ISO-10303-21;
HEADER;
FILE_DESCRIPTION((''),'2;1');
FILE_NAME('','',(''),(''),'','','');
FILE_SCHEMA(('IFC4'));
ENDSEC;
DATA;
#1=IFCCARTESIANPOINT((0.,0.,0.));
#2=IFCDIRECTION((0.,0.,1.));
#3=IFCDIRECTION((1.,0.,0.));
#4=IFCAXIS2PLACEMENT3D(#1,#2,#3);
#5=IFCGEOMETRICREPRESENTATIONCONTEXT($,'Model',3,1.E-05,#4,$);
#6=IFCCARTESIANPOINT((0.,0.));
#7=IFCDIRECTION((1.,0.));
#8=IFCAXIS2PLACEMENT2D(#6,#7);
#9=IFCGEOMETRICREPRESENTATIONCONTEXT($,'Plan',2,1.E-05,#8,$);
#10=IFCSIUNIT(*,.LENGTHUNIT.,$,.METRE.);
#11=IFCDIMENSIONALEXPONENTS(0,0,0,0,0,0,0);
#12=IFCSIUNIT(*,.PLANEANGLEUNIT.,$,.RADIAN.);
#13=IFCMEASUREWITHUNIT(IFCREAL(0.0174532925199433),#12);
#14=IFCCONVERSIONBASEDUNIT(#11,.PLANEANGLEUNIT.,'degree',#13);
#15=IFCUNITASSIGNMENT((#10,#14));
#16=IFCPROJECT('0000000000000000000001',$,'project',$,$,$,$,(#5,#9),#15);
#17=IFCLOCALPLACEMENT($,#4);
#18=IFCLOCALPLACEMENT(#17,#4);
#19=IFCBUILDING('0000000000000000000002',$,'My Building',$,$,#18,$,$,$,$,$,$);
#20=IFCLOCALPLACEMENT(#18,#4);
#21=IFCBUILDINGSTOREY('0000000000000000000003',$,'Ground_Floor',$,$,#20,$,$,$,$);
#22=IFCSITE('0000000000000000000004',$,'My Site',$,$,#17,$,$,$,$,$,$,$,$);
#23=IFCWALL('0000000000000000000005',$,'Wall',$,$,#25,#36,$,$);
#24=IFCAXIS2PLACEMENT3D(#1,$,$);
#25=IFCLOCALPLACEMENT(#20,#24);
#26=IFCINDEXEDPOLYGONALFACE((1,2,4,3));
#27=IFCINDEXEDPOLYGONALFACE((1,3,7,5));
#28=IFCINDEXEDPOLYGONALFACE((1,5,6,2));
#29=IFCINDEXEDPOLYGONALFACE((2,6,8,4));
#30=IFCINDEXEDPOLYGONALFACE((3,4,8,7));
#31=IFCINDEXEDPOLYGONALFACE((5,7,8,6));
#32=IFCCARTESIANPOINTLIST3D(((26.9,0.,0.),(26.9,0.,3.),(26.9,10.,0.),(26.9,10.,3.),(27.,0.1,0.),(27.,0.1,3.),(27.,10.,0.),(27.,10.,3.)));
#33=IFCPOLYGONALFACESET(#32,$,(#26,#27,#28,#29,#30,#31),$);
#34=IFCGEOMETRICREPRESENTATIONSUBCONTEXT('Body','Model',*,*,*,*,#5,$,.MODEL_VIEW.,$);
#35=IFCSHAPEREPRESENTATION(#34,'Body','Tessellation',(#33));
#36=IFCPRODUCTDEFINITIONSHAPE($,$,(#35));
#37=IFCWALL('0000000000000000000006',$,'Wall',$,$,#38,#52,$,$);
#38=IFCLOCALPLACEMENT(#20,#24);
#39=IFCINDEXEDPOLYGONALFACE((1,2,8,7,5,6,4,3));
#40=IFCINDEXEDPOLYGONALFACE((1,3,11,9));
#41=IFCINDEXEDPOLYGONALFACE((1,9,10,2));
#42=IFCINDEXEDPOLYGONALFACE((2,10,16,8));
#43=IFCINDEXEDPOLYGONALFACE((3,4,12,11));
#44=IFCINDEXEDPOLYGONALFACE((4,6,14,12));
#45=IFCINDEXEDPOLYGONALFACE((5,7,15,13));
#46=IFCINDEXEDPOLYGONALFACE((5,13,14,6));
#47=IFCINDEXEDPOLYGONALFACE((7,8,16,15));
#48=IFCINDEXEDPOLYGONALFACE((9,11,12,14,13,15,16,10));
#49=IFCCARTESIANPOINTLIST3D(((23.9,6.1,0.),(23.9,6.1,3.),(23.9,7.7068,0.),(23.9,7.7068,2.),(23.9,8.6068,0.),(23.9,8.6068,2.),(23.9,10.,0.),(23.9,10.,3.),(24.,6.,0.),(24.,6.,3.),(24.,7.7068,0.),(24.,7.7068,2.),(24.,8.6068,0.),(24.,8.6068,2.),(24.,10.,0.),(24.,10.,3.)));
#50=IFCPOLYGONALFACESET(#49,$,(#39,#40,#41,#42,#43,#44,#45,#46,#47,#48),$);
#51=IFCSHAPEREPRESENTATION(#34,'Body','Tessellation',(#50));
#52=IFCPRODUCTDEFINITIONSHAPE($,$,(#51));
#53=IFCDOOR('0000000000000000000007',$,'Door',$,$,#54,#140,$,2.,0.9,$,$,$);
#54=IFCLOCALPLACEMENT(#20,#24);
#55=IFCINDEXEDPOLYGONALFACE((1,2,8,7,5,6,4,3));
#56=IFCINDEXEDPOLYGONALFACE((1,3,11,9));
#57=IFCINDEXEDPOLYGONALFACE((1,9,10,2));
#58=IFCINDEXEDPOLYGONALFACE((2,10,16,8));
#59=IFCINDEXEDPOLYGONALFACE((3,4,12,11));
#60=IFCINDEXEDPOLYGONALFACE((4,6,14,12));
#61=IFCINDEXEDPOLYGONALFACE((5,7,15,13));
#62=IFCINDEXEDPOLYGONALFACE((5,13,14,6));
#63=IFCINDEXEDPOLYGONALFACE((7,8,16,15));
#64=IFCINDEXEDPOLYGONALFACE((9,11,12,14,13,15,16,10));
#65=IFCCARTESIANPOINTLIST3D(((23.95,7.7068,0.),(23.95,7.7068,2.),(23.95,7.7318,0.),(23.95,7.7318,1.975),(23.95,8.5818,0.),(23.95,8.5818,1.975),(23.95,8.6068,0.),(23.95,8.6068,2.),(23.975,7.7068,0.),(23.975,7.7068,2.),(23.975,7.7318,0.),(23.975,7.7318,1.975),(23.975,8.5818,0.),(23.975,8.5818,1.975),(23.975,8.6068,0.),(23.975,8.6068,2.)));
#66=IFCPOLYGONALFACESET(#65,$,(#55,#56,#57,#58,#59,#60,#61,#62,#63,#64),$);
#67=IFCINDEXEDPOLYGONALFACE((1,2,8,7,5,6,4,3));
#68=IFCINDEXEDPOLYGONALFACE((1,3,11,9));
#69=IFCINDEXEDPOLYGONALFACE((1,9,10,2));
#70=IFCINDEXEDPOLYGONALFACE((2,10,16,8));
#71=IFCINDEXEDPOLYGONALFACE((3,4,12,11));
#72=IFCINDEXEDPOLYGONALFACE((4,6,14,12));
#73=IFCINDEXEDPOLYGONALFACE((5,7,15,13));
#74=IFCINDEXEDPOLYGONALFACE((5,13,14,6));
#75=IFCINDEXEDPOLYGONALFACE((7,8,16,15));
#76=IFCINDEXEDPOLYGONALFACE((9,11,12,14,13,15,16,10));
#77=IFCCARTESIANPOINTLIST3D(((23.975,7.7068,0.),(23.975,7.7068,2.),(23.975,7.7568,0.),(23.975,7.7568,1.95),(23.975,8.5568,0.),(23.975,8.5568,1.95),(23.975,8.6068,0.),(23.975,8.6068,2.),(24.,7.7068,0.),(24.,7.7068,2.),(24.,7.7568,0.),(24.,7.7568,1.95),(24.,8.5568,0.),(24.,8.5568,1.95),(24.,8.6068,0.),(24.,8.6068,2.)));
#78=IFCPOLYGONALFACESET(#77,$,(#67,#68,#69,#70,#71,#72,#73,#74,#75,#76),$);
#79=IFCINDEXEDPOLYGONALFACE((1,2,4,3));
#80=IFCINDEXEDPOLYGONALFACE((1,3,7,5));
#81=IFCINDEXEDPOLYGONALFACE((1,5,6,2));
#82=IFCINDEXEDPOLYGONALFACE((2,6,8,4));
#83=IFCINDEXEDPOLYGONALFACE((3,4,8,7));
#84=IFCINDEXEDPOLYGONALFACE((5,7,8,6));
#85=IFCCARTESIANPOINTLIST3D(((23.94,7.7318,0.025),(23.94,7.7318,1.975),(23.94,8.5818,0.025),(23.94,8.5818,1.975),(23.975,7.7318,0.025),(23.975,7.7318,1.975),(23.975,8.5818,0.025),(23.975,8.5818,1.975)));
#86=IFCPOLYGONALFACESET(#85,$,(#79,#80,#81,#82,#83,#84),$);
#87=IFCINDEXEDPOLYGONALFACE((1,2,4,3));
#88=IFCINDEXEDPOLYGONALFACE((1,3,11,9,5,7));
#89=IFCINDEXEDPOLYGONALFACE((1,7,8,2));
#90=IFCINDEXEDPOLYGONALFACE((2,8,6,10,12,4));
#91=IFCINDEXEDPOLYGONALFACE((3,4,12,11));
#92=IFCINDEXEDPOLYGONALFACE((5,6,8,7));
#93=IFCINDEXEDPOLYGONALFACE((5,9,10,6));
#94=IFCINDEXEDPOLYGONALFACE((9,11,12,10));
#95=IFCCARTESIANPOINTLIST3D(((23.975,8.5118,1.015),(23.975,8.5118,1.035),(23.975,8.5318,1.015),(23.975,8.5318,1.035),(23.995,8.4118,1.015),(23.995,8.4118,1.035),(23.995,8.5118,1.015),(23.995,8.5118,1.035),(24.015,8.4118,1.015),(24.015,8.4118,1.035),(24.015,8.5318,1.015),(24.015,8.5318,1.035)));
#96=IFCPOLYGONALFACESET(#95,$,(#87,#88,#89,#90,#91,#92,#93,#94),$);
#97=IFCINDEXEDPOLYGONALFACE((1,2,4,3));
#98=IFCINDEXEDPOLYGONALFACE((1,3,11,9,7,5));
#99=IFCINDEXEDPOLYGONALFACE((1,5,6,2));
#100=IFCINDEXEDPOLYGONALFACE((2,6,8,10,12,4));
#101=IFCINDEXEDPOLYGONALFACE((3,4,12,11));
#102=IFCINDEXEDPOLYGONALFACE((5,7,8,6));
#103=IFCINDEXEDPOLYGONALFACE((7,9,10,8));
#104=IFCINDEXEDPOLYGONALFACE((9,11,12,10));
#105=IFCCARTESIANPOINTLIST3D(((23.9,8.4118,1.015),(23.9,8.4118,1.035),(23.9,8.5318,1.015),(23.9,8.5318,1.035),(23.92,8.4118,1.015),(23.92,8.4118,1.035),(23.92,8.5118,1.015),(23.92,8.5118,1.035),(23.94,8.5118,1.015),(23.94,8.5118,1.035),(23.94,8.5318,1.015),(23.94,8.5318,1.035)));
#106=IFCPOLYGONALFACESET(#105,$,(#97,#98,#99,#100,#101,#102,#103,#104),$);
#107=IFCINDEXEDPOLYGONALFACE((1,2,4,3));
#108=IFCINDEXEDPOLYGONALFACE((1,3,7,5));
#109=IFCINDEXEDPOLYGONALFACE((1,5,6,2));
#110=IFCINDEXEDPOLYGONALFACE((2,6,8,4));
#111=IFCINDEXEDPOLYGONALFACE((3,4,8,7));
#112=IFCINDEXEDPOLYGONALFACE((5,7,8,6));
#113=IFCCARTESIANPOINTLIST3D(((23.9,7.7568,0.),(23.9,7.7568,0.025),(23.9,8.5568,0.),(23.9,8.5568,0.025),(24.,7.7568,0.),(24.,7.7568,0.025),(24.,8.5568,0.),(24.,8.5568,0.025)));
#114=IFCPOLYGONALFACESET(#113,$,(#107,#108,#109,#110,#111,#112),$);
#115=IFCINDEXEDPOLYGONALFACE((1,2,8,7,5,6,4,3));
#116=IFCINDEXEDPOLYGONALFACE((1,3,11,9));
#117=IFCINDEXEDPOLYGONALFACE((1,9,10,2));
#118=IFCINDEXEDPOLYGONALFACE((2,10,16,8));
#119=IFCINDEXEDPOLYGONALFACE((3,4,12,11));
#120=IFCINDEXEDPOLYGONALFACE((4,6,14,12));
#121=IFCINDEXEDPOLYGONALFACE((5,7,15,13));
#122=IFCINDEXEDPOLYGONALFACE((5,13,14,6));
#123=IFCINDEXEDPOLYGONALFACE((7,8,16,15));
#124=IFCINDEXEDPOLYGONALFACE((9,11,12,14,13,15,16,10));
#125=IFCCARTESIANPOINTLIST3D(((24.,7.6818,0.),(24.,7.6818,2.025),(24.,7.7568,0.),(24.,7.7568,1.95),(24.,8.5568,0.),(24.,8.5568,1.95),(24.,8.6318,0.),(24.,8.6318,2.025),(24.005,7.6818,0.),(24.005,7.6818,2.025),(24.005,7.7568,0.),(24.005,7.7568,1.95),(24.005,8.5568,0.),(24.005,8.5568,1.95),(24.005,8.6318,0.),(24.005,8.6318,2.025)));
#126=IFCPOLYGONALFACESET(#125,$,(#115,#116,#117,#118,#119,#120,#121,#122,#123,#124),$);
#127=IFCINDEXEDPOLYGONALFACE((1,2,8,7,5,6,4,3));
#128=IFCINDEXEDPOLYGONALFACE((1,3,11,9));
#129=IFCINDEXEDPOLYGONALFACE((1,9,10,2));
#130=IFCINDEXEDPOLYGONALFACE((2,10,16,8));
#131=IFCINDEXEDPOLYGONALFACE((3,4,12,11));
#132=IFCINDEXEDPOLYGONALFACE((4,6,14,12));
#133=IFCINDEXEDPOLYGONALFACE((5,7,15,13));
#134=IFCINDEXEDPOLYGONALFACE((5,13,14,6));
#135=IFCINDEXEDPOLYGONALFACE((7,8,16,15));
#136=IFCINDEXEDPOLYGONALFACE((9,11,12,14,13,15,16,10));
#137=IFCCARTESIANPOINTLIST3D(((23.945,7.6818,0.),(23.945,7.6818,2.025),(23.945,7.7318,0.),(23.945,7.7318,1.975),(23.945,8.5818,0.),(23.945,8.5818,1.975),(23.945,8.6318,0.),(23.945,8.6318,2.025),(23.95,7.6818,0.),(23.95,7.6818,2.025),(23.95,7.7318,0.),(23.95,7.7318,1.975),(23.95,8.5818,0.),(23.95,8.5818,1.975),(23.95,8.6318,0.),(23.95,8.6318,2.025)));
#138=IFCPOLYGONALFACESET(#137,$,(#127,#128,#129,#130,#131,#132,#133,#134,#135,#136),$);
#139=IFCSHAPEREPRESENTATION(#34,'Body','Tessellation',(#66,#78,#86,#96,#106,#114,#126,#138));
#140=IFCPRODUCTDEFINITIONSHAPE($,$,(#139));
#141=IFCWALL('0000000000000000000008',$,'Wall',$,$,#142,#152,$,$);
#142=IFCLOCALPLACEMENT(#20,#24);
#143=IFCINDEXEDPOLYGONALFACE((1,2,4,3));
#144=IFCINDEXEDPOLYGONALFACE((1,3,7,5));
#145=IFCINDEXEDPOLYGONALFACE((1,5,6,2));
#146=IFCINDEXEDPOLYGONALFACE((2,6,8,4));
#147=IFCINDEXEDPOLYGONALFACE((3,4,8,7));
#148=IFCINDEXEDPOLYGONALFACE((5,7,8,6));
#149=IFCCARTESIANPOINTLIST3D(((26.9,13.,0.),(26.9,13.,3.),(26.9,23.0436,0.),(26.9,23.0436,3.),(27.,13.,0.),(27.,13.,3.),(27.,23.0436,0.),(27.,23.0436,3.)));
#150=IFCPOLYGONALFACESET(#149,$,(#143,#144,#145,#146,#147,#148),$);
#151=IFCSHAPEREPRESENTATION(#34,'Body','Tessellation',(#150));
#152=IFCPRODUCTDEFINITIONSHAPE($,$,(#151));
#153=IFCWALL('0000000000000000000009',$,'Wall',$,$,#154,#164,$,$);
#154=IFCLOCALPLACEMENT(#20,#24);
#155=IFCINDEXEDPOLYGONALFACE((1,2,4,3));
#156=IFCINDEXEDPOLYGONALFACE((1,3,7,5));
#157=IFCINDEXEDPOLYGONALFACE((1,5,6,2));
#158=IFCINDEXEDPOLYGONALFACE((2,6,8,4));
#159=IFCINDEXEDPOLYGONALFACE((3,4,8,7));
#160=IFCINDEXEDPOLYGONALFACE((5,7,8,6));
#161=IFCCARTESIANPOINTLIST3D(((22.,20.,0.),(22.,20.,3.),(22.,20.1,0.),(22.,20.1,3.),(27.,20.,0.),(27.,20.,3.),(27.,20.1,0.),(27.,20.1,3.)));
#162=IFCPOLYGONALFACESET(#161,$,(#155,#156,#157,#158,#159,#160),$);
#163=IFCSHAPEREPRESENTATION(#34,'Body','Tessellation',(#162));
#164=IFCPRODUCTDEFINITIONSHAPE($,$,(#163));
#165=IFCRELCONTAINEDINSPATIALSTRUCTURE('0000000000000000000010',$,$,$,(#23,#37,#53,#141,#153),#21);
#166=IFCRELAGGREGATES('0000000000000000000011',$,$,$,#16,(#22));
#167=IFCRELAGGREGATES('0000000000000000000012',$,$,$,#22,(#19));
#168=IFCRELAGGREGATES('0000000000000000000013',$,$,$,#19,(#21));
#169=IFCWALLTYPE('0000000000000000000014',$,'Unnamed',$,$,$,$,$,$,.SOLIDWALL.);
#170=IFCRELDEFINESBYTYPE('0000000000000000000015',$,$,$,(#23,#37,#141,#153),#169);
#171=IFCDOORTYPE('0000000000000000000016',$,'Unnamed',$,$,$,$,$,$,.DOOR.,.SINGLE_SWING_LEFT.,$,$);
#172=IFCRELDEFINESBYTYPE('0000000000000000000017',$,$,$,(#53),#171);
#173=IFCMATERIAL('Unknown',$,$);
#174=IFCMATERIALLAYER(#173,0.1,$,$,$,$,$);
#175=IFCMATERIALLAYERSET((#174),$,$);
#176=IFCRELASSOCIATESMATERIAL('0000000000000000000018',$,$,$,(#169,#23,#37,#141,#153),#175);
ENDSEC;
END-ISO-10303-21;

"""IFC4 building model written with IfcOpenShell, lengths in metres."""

from ifc_helpers import new_model, entity, si_unit, converted_unit, frame, origin_with_axes, origin_2d_with_axis, place, context, subcontext, project, spatial, line, indexed_curve, outline, extrude, shape, source, transform, mapped, material, layer, layer_set, layer_usage, type_object, type_shapes, element, fill, save


model = new_model("IFC4")

# Units and contexts
model_context = context("Model", 3, precision=1e-05, world=origin_with_axes())
plan_context = context("Plan", 2, precision=1e-05, world=origin_2d_with_axis())
body_context_1 = subcontext(model_context, "Body", "Model", "MODEL_VIEW")
body_context_2 = subcontext(plan_context, "Body", "Plan", "PLAN_VIEW")
ifc_project = project(units=[si_unit("LENGTHUNIT", "METRE"), converted_unit("PLANEANGLEUNIT", "degree", entity("IfcReal", 0.0174532925199433), si_unit("PLANEANGLEUNIT", "RADIAN"), dimensions=[0, 0, 0, 0, 0, 0, 0])], contexts=[model_context, plan_context])

# Site, building, storey
site_placement = place(None, origin_with_axes())
site = spatial("IfcSite", under=ifc_project, at=site_placement, Name="My Site")
building_placement = place(site_placement, origin_with_axes())
building = spatial("IfcBuilding", under=site, at=building_placement, Name="My Building")
storey_placement = place(building_placement, origin_with_axes())
storey = spatial("IfcBuildingStorey", under=building, at=storey_placement, Name="Ground_Floor")

# Wall
ifc_material = material(Name="Unknown")
ifc_layer = layer(ifc_material, 0.1)
ifc_layer_set = layer_set([ifc_layer])
ifc_layer_usage_1 = layer_usage(ifc_layer_set, "AXIS2", "POSITIVE", 0.0)
wall_type = type_object("IfcWallType", Name="Unnamed", PredefinedType="SOLIDWALL", material=ifc_layer_set)
wall_1_placement = place(storey_placement, frame((27.0, 0.0, 0.0), z_axis=(0.0, 0.0, 1.0), x_axis=(0.0, 1.0, 0.0)))
element("IfcWall", 1, at=wall_1_placement, inside=storey, type_object=wall_type, material=ifc_layer_usage_1, Name="Wall", context=body_context_1, shape_type="SweptSolid", body=[
    extrude(outline(indexed_curve([(0.1, 0.0), (0.0, 0.1), (10.0, 0.1), (10.0, 0.0)], segments=[line(1, 2, 3, 4, 1)])), origin_with_axes(), (0.0, 0.0, 1.0), 3.0),
])

# Wall, opening, door
ifc_layer_usage_2 = layer_usage(ifc_layer_set, "AXIS2", "POSITIVE", 0.0)
wall_2_placement = place(storey_placement, frame((24.0, 6.0, 0.0), z_axis=(0.0, 0.0, 1.0), x_axis=(0.0, 1.0, 0.0)))
wall_2 = element("IfcWall", 2, at=wall_2_placement, inside=storey, type_object=wall_type, material=ifc_layer_usage_2, Name="Wall", context=body_context_1, shape_type="SweptSolid", body=[
    extrude(outline(indexed_curve([(0.0, 0.0), (0.1, 0.1), (4.0, 0.1), (4.0, 0.0)], segments=[line(1, 2, 3, 4, 1)])), origin_with_axes(), (0.0, 0.0, 1.0), 3.0),
])
shared_shape_1 = source(origin_with_axes(), body_context_1, "Body", "SweptSolid", [
    extrude(outline(indexed_curve([(0.0, 0.0), (0.9, 0.0), (0.9, 2.0), (0.0, 2.0)], segments=[line(1, 2, 3, 4, 1)])), frame((0.0, -0.6, 0.0), z_axis=(0.0, -1.0, 0.0), x_axis=(1.0, 0.0, 0.0)), (0.0, 0.0, -1.0), 1.2),
])
opening_1_placement = place(wall_2_placement, frame((1.7068, 0.0, 0.0), z_axis=(0.0, 0.0, 1.0), x_axis=(1.0, 0.0, 0.0)))
opening_1 = element("IfcOpeningElement", 3, at=opening_1_placement, cuts=wall_2, PredefinedType="OPENING", context=body_context_1, shape_type="MappedRepresentation", body=[
    mapped(shared_shape_1, transform((0.0, 0.0, 0.0), x_axis=(1.0, 0.0, 0.0), y_axis=(0.0, 1.0, 0.0), z_axis=(0.0, 0.0, 1.0), scale=1.0)),
])
door_type_1 = type_object("IfcDoorType", Name="Unnamed", OperationType="SINGLE_SWING_LEFT", PredefinedType="DOOR")
shared_shape_2 = source(origin_with_axes(), body_context_1, "Body", "SweptSolid", [
    extrude(outline(indexed_curve([(0.0, 0.0), (0.0, 2.0), (0.9, 2.0), (0.9, 0.0), (0.875, 0.0), (0.875, 1.975), (0.025, 1.975), (0.025, 0.0)], segments=[line(1, 2, 3, 4, 5, 6, 7, 8, 1)])), frame((0.0, 0.025, 0.0), z_axis=(0.0, -1.0, 0.0), x_axis=(1.0, 0.0, 0.0)), (0.0, 0.0, -1.0), 0.025),
    extrude(outline(indexed_curve([(0.0, 0.0), (0.0, 2.0), (0.9, 2.0), (0.9, 0.0), (0.85, 0.0), (0.85, 1.95), (0.05, 1.95), (0.05, 0.0)], segments=[line(1, 2, 3, 4, 5, 6, 7, 8, 1)])), frame((0.0, 0.0, 0.0), z_axis=(0.0, -1.0, 0.0), x_axis=(1.0, 0.0, 0.0)), (0.0, 0.0, -1.0), 0.025),
    extrude(outline(indexed_curve([(0.0, 0.0), (0.85, 0.0), (0.85, 0.035), (0.0, 0.035)], segments=[line(1, 2, 3, 4, 1)])), frame((0.025, 0.025, 0.025), z_axis=(0.0, 0.0, 1.0), x_axis=(1.0, 0.0, 0.0)), (0.0, 0.0, 1.0), 1.95),
    extrude(outline(indexed_curve([(0.0, 0.0), (0.0, -0.04), (-0.12, -0.04), (-0.12, -0.02), (-0.02, -0.02), (-0.02, 0.0)], segments=[line(1, 2, 3, 4, 5, 6, 1)])), frame((0.825, 0.025, 1.015), z_axis=(0.0, 0.0, 1.0), x_axis=(1.0, 0.0, 0.0)), (0.0, 0.0, 1.0), 0.02),
    extrude(outline(indexed_curve([(0.0, 0.0), (0.0, 0.04), (-0.12, 0.04), (-0.12, 0.02), (-0.02, 0.02), (-0.02, 0.0)], segments=[line(1, 2, 3, 4, 5, 6, 1)])), frame((0.825, 0.06, 1.015), z_axis=(0.0, 0.0, 1.0), x_axis=(1.0, 0.0, 0.0)), (0.0, 0.0, 1.0), 0.02),
    extrude(outline(indexed_curve([(0.0, 0.0), (0.8, 0.0), (0.8, 0.1), (0.0, 0.1)], segments=[line(1, 2, 3, 4, 1)])), frame((0.05, 0.0, 0.0), z_axis=(0.0, 0.0, 1.0), x_axis=(1.0, 0.0, 0.0)), (0.0, 0.0, 1.0), 0.025),
    extrude(outline(indexed_curve([(0.0, 0.0), (0.0, 2.025), (0.95, 2.025), (0.95, 0.0), (0.875, 0.0), (0.875, 1.95), (0.075, 1.95), (0.075, 0.0)], segments=[line(1, 2, 3, 4, 5, 6, 7, 8, 1)])), frame((-0.025, -0.005, 0.0), z_axis=(0.0, -1.0, 0.0), x_axis=(1.0, 0.0, 0.0)), (0.0, 0.0, -1.0), 0.005),
    extrude(outline(indexed_curve([(0.0, 0.0), (0.0, 2.025), (0.95, 2.025), (0.95, 0.0), (0.9, 0.0), (0.9, 1.975), (0.05, 1.975), (0.05, 0.0)], segments=[line(1, 2, 3, 4, 5, 6, 7, 8, 1)])), frame((-0.025, 0.05, 0.0), z_axis=(0.0, -1.0, 0.0), x_axis=(1.0, 0.0, 0.0)), (0.0, 0.0, -1.0), 0.005),
])
shared_shape_3 = source(origin_with_axes(), body_context_2, "Body", "Curve2D", [
    entity("IfcIndexedPolyCurve", entity("IfcCartesianPointList2D", [[0.0, 0.0], [0.0, 0.05], [0.025, 0.05], [0.025, 0.025], [0.05, 0.025], [0.05, 0.0]]), [entity("IfcLineIndex", [1, 2, 3, 4, 5, 6, 1])]),
    entity("IfcIndexedPolyCurve", entity("IfcCartesianPointList2D", [[0.9, 0.0], [0.9, 0.05], [0.875, 0.05], [0.875, 0.025], [0.85, 0.025], [0.85, 0.0]]), [entity("IfcLineIndex", [1, 2, 3, 4, 5, 6, 1])]),
    entity("IfcTrimmedCurve", entity("IfcEllipse", entity("IfcAxis2Placement2D", entity("IfcCartesianPoint", [0.06, 0.05]), entity("IfcDirection", [1.0, 0.0])), 0.815, 0.85), [entity("IfcCartesianPoint", [0.875, 0.05])], [entity("IfcCartesianPoint", [0.06, 0.9])], True, "CARTESIAN"),
    entity("IfcIndexedPolyCurve", entity("IfcCartesianPointList2D", [[0.025, 0.05], [0.06, 0.05], [0.06, 0.9], [0.025, 0.9]]), [entity("IfcLineIndex", [1, 2, 3, 4, 1])]),
])
type_shapes(door_type_1, [shared_shape_2, shared_shape_3])
door_1_placement = place(opening_1_placement, frame((0.0, 0.0, 0.0), z_axis=(0.0, 0.0, 1.0), x_axis=(1.0, 0.0, 0.0)))
door_1 = element("IfcDoor", 4, at=door_1_placement, inside=storey, type_object=door_type_1, Name="Door", OverallHeight=2.0, OverallWidth=0.9, shapes=[
    shape(body_context_1, "Body", "MappedRepresentation", [mapped(shared_shape_2, transform((0.0, 0.0, 0.0), x_axis=(1.0, 0.0, 0.0), y_axis=(0.0, 1.0, 0.0), z_axis=(0.0, 0.0, 1.0), scale=1.0))]),
    shape(body_context_2, "Body", "MappedRepresentation", [mapped(shared_shape_3, transform((0.0, 0.0, 0.0), x_axis=(1.0, 0.0, 0.0), y_axis=(0.0, 1.0, 0.0), z_axis=(0.0, 0.0, 1.0), scale=1.0))]),
])
fill(opening_1, door_1)

# Walls
ifc_layer_usage_3 = layer_usage(ifc_layer_set, "AXIS2", "POSITIVE", 0.0)
wall_3_placement = place(storey_placement, frame((27.0, 13.0, 0.0), z_axis=(0.0, 0.0, 1.0), x_axis=(0.0, 1.0, 0.0)))
element("IfcWall", 5, at=wall_3_placement, inside=storey, type_object=wall_type, material=ifc_layer_usage_3, Name="Wall", context=body_context_1, shape_type="SweptSolid", body=[
    extrude(outline(indexed_curve([(0.0, 0.0), (0.0, 0.1), (10.0436, 0.1), (10.0436, 0.0)], segments=[line(1, 2, 3, 4, 1)])), origin_with_axes(), (0.0, 0.0, 1.0), 3.0),
])
ifc_layer_usage_4 = layer_usage(ifc_layer_set, "AXIS2", "POSITIVE", 0.0)
wall_4_placement = place(storey_placement, frame((22.0, 20.0, 0.0), z_axis=(0.0, 0.0, 1.0), x_axis=(1.0, 0.0, 0.0)))
element("IfcWall", 6, at=wall_4_placement, inside=storey, type_object=wall_type, material=ifc_layer_usage_4, Name="Wall", context=body_context_1, shape_type="SweptSolid", body=[
    extrude(outline(indexed_curve([(0.0, 0.0), (0.0, 0.1), (5.0, 0.1), (5.0, 0.0)], segments=[line(1, 2, 3, 4, 1)])), origin_with_axes(), (0.0, 0.0, 1.0), 3.0),
])

save(model, "model.ifc")
